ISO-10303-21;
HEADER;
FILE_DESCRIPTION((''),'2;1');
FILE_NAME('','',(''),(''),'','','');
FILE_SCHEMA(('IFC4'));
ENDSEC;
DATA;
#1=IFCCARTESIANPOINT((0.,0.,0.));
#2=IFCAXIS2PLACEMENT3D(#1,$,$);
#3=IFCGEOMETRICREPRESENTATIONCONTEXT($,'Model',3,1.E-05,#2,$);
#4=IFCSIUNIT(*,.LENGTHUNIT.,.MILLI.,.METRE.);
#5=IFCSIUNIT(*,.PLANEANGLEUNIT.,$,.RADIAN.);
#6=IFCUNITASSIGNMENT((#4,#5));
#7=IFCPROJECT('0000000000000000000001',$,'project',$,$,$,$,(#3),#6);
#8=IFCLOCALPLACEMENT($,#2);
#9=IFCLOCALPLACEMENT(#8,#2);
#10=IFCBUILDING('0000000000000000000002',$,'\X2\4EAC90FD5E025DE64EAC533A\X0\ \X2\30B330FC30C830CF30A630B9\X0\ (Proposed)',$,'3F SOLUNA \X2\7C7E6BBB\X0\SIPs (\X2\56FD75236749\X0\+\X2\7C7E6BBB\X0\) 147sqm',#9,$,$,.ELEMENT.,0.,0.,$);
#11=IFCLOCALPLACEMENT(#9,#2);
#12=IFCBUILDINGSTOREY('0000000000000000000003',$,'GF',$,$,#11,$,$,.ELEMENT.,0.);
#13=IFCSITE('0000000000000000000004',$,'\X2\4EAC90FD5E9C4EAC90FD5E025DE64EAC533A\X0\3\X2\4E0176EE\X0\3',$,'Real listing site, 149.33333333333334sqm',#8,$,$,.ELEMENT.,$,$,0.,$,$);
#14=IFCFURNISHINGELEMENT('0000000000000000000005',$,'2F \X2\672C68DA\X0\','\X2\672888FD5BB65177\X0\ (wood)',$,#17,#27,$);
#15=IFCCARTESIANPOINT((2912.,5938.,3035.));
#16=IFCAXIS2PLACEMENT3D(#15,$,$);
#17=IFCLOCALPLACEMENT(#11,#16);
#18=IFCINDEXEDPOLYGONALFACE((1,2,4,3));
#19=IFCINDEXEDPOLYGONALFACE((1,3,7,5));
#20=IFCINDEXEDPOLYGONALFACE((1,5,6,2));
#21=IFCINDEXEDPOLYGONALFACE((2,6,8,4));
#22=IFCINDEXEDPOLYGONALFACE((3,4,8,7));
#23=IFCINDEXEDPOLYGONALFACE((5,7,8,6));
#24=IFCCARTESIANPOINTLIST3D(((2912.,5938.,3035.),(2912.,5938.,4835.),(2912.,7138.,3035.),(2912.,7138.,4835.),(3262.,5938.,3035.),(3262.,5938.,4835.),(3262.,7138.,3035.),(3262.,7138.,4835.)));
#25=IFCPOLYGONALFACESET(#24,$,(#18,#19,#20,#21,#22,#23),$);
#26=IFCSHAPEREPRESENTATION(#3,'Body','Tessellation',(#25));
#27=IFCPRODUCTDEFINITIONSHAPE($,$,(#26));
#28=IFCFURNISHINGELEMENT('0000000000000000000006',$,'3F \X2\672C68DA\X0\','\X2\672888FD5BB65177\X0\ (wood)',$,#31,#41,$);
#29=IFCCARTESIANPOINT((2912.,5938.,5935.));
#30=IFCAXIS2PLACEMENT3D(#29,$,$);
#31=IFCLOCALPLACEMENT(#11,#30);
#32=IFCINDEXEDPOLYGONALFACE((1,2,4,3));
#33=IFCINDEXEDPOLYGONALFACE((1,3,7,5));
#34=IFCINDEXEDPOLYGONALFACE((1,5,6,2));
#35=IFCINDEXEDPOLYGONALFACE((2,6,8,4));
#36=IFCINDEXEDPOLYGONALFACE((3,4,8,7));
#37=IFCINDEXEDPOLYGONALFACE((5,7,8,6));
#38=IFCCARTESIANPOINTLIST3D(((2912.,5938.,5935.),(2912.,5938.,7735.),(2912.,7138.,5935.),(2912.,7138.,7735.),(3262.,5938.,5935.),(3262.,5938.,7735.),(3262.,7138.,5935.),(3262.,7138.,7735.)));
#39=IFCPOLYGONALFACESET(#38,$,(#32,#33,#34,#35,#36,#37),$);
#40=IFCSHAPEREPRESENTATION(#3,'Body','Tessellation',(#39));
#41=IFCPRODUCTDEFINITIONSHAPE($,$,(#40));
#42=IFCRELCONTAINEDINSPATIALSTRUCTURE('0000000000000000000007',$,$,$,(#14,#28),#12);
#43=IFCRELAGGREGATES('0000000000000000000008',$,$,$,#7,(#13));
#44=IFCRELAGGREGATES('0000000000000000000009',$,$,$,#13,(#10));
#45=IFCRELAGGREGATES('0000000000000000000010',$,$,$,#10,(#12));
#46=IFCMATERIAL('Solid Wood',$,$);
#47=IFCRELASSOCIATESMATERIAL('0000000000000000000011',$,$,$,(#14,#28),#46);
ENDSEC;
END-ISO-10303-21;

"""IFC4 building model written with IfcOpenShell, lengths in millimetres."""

from ifc_helpers import new_model, si_unit, frame, frame_2d, origin, place, context, project, spatial, rectangle, extrude, material, element, save


model = new_model("IFC4")

# Units and contexts
model_context = context("Model", 3, precision=1e-05, world=origin())
ifc_project = project(units=[si_unit("LENGTHUNIT", "METRE", prefix="MILLI"), si_unit("PLANEANGLEUNIT", "RADIAN")], contexts=[model_context])

# Site, building, storey
site_placement = place(None, origin())
site = spatial("IfcSite", under=ifc_project, at=site_placement, Name="京都府京都市左京区3丁目3", ObjectType="Real listing site, 149.33333333333334sqm", CompositionType="ELEMENT", RefElevation=0.0)
building_placement = place(site_placement, origin())
building = spatial("IfcBuilding", under=site, at=building_placement, Name="京都市左京区 コートハウス (Proposed)", ObjectType="3F SOLUNA 籾殻SIPs (国産杉+籾殻) 147sqm", CompositionType="ELEMENT", ElevationOfRefHeight=0.0, ElevationOfTerrain=0.0)
storey_placement = place(building_placement, origin())
storey = spatial("IfcBuildingStorey", under=building, at=storey_placement, Name="GF", CompositionType="ELEMENT", Elevation=0.0)

# Shared definitions
ifc_material_1 = material(Name="Solid Wood")

# Furnishing elements
furnishing_1_placement = place(storey_placement, frame((2912.0, 5938.0, 3035.0)))
element("IfcFurnishingElement", 1, at=furnishing_1_placement, inside=storey, material=ifc_material_1, Name="2F 本棚", Description="木製家具 (wood)", context=model_context, shape_type="SweptSolid", body=[
    extrude(rectangle(XDim=350.0, YDim=1200.0, at=frame_2d((175.0, 600.0))), frame((2912.0, 5938.0, 3035.0)), (0.0, 0.0, 1.0), 1800.0),
])
furnishing_2_placement = place(storey_placement, frame((2912.0, 5938.0, 5935.0)))
element("IfcFurnishingElement", 2, at=furnishing_2_placement, inside=storey, material=ifc_material_1, Name="3F 本棚", Description="木製家具 (wood)", context=model_context, shape_type="SweptSolid", body=[
    extrude(rectangle(XDim=350.0, YDim=1200.0, at=frame_2d((175.0, 600.0))), frame((2912.0, 5938.0, 5935.0)), (0.0, 0.0, 1.0), 1800.0),
])

save(model, "model.ifc")
